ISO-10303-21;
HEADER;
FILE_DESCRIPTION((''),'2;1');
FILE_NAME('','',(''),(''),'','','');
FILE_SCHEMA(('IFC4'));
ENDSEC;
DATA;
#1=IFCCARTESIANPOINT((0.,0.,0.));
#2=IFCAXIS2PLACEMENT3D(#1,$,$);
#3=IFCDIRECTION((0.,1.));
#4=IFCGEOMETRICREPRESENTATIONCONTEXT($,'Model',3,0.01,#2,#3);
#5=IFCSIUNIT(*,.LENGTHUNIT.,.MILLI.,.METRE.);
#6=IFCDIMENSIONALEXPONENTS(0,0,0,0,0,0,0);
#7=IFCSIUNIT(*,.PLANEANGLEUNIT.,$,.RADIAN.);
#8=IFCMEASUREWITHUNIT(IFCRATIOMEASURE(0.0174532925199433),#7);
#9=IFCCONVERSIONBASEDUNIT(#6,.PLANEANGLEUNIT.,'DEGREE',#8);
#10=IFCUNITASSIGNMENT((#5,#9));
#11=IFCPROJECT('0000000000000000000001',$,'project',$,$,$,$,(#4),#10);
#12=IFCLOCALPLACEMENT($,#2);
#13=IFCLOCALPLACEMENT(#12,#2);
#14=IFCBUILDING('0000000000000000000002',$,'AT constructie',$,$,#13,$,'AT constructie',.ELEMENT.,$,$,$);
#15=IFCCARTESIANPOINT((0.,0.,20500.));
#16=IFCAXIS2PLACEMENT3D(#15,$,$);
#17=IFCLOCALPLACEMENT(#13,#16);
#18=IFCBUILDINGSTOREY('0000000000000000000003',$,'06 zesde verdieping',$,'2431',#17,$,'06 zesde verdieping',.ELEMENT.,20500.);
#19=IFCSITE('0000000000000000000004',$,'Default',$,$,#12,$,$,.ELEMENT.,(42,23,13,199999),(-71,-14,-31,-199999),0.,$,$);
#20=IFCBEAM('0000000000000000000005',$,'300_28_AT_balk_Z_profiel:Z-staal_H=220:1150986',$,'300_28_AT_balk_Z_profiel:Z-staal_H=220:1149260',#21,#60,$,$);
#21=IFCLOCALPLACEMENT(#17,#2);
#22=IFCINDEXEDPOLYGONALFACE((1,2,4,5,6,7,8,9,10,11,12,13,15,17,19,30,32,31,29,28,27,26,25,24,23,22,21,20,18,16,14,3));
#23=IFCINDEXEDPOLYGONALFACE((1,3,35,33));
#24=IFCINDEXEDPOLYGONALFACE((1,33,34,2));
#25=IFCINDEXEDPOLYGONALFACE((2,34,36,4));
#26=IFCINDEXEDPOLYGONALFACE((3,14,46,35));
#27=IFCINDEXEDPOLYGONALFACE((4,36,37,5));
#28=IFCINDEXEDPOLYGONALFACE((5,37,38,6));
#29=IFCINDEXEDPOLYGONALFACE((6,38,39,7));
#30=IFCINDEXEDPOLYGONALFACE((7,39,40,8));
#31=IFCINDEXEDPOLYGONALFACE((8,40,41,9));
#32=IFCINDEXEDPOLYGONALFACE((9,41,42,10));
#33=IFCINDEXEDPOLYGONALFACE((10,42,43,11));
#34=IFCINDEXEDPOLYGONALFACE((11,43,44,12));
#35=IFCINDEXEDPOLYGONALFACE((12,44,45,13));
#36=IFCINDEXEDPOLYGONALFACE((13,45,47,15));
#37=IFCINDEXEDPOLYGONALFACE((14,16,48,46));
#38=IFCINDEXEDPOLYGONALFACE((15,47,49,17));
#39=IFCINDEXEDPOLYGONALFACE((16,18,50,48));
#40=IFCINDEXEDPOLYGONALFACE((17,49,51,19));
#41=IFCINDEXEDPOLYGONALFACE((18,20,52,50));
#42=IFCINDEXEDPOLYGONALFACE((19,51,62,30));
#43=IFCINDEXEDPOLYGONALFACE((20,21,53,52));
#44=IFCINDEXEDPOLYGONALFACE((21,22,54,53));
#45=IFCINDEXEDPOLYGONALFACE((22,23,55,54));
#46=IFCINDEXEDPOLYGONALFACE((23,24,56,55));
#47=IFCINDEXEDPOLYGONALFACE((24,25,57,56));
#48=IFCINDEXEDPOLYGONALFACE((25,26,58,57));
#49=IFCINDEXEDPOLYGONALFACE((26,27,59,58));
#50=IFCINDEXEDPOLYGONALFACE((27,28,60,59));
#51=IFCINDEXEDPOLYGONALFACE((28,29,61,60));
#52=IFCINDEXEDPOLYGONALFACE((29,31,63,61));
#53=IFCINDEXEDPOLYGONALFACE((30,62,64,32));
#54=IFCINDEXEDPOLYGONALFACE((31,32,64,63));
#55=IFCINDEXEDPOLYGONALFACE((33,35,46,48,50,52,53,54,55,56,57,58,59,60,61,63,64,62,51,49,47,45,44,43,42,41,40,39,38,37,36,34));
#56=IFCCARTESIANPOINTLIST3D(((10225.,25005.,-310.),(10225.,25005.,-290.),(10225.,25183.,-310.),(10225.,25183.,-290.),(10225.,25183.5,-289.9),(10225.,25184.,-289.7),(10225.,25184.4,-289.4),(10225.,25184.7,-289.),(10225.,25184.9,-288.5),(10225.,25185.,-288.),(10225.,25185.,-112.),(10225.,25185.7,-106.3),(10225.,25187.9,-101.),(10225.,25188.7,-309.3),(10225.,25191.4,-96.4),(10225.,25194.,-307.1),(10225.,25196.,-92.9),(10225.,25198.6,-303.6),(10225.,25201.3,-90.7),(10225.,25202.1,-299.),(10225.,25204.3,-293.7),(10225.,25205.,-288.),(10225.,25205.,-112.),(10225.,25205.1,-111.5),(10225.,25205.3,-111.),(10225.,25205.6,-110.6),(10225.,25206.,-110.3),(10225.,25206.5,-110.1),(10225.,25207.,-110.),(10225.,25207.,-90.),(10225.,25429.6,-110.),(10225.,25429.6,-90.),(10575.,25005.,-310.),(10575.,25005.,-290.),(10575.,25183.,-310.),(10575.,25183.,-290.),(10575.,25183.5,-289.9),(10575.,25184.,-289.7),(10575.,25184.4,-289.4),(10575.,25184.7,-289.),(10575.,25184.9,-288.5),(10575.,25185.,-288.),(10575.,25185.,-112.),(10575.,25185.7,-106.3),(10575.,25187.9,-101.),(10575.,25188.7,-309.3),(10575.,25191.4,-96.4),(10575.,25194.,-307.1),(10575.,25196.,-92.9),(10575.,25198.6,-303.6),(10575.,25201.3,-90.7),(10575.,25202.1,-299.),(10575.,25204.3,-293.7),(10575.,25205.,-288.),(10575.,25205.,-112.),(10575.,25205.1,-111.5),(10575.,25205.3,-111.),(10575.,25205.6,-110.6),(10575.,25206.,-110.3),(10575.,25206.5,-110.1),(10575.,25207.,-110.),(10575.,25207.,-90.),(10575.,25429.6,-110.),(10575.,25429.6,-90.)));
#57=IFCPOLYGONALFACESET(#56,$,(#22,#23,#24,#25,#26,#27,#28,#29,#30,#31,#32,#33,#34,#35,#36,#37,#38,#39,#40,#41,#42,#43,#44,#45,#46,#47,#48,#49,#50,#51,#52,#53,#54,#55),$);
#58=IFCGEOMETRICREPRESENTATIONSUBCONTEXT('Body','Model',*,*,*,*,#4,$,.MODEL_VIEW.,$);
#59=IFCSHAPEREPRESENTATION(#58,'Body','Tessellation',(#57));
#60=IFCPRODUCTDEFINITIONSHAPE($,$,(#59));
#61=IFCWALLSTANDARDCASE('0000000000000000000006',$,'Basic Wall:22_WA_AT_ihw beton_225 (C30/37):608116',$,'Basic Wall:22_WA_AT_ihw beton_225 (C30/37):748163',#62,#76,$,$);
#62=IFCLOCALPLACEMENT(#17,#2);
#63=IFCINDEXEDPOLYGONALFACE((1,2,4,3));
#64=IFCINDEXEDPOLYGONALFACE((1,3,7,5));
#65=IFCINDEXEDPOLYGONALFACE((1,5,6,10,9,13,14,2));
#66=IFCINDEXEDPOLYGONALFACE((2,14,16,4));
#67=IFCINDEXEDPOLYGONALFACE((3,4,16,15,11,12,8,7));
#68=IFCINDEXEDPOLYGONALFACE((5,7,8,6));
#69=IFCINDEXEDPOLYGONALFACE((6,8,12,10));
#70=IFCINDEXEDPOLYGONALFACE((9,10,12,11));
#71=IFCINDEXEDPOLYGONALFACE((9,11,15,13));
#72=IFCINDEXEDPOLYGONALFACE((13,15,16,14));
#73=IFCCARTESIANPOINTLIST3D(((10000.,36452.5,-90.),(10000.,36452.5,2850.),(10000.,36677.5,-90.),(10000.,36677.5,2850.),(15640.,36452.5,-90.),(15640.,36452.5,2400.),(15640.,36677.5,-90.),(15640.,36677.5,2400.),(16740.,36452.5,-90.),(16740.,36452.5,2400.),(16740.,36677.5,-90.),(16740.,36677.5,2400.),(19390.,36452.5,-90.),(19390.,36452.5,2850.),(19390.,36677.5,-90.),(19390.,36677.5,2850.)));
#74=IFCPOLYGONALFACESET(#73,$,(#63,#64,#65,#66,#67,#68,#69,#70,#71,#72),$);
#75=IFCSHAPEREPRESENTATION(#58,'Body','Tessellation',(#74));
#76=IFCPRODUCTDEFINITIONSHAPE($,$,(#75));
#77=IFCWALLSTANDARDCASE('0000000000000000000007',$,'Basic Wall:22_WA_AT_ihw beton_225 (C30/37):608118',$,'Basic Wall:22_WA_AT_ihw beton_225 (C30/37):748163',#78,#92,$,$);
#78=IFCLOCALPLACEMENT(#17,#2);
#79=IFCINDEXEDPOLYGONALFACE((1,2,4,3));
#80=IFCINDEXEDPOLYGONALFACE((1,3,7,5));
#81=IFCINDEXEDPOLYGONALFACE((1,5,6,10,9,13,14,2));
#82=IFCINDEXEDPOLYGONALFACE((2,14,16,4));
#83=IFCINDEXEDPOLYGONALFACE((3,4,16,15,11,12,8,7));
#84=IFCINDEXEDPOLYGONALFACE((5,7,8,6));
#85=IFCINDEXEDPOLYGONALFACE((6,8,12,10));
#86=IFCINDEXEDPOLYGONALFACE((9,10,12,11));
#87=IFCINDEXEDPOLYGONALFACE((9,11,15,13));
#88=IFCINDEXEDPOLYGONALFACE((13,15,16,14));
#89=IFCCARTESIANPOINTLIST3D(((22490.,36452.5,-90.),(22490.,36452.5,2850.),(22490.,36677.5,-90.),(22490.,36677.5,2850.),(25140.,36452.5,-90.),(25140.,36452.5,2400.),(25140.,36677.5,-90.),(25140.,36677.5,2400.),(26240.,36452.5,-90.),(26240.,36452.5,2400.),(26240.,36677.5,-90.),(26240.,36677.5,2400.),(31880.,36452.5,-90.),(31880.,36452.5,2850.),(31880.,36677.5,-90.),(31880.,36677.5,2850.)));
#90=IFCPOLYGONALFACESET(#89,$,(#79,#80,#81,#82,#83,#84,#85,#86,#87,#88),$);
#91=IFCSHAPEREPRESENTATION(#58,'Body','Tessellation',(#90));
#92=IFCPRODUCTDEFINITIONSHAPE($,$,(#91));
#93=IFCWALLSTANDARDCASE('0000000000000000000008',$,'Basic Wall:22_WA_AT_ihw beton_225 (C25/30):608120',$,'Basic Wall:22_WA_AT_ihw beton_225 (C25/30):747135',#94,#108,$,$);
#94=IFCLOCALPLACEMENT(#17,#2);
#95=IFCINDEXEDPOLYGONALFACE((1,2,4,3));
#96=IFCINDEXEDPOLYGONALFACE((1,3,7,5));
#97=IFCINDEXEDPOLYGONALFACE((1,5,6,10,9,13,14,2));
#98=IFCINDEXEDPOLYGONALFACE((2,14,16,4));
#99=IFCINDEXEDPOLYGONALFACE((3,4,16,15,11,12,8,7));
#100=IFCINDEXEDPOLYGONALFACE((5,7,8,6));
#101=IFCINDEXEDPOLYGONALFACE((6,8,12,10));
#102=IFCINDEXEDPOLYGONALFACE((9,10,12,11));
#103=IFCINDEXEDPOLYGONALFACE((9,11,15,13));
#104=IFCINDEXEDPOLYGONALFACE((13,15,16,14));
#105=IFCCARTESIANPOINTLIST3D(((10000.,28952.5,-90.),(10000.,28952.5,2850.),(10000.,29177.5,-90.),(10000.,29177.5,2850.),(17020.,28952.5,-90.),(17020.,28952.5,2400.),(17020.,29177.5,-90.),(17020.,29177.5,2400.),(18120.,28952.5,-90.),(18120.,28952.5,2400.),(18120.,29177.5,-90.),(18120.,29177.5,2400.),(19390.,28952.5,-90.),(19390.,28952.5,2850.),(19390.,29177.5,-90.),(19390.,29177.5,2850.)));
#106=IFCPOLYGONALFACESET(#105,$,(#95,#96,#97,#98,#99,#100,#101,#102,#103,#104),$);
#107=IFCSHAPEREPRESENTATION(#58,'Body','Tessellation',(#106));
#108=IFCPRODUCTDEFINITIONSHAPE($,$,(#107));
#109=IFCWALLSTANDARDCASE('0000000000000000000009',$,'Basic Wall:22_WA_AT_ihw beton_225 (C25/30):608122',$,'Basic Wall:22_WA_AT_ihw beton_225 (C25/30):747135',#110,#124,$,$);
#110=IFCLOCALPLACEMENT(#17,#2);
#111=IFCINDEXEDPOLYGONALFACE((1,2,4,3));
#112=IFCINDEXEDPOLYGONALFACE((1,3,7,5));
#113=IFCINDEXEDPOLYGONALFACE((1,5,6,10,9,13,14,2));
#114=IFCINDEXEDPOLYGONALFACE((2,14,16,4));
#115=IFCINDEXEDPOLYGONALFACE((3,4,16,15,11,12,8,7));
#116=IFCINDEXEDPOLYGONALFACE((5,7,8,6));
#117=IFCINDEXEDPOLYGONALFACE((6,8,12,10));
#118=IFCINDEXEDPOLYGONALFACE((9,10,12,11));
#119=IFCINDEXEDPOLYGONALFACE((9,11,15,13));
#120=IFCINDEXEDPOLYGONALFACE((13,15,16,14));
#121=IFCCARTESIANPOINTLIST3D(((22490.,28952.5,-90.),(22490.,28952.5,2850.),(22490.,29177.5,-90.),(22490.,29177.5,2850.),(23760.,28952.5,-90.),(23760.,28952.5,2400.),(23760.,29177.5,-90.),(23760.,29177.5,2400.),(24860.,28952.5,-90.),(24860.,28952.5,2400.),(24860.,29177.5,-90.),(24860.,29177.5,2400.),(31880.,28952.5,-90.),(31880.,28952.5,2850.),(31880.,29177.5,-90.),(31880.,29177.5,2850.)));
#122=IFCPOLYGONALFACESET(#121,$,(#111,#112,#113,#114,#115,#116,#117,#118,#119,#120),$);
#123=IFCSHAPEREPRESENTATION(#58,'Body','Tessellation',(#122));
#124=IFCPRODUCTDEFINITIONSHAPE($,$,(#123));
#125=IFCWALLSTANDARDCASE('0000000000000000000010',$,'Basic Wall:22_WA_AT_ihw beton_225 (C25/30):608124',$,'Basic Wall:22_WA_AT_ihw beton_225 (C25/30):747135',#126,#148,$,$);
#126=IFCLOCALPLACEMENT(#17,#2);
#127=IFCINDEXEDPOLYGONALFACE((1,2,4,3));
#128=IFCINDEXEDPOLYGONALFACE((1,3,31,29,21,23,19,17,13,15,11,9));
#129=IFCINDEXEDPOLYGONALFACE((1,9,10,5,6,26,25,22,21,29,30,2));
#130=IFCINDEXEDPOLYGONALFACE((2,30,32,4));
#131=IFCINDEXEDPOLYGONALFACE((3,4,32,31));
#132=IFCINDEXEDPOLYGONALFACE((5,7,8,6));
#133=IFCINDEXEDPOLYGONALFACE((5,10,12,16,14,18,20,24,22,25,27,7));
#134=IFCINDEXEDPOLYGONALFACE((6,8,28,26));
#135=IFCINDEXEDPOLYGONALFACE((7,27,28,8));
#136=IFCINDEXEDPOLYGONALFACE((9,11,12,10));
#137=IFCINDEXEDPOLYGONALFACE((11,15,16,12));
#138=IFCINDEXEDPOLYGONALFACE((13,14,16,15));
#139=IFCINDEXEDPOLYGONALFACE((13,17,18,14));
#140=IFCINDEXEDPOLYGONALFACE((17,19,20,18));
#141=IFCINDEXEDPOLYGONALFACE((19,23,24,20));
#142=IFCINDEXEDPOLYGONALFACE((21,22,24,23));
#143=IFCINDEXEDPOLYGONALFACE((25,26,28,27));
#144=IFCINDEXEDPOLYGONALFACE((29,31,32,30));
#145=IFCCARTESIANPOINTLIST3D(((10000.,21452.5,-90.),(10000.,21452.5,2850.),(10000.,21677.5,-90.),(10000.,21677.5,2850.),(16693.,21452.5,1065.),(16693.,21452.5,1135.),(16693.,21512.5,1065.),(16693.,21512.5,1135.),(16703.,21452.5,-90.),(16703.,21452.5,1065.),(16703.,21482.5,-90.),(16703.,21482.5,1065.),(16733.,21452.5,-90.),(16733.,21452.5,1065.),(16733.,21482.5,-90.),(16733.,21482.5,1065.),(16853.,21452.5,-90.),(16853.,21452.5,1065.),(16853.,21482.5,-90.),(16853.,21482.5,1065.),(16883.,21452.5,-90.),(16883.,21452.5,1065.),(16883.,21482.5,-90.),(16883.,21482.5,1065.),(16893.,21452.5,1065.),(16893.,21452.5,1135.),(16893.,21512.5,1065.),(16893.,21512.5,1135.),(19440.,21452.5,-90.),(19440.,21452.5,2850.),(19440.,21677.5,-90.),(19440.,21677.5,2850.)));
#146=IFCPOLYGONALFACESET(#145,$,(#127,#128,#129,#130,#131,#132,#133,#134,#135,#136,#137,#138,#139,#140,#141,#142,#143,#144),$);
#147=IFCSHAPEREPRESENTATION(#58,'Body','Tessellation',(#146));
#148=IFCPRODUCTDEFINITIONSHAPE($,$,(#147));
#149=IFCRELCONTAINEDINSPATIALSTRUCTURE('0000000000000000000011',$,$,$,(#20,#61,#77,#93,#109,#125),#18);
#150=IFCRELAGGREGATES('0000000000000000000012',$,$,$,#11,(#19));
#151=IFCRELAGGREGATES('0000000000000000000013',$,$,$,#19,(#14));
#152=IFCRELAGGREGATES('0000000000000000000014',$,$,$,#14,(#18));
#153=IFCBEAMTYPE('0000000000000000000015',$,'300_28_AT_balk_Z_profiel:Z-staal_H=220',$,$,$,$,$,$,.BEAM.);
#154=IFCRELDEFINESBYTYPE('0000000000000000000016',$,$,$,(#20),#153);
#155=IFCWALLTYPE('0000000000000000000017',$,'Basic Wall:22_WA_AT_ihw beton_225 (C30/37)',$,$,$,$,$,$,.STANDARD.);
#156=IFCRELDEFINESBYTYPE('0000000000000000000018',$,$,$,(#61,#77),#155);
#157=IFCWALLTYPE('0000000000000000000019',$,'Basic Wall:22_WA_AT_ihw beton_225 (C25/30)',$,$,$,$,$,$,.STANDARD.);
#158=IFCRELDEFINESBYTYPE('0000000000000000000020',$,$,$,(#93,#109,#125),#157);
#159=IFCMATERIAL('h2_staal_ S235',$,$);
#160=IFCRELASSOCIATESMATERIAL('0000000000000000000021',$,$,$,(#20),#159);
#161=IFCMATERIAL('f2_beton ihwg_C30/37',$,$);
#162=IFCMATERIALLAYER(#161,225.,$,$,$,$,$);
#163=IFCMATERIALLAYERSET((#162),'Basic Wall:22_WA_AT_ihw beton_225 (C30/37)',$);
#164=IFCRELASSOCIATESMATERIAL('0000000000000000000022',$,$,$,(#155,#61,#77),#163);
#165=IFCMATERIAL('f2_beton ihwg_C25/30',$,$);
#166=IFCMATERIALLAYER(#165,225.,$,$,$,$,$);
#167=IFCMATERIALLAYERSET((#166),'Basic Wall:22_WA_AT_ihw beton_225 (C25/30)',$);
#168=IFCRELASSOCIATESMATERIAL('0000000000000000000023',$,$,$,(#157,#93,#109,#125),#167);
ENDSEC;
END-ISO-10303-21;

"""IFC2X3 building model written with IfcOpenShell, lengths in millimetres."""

from ifc_helpers import new_model, entity, si_unit, converted_unit, direction, frame, frame_2d, origin, place, context, subcontext, project, spatial, polyline, circle_curve, parameter, trimmed, segment, composite_curve, rectangle, outline, extrude, material, layer, layer_set, layer_usage, type_object, element, save


model = new_model("IFC2X3")

# Units and contexts
model_context = context("Model", 3, precision=0.01, world=origin(), true_north=direction((0.0, 1.0)))
body_context = subcontext(model_context, "Body", "Model", "MODEL_VIEW")
ifc_project = project(units=[si_unit("LENGTHUNIT", "METRE", prefix="MILLI"), converted_unit("PLANEANGLEUNIT", "DEGREE", entity("IfcRatioMeasure", 0.0174532925199433), si_unit("PLANEANGLEUNIT", "RADIAN"), dimensions=[0, 0, 0, 0, 0, 0, 0])], contexts=[model_context])

# Site, building, storey
site_placement = place(None, origin())
site = spatial("IfcSite", under=ifc_project, at=site_placement, Name="Default", CompositionType="ELEMENT", RefLatitude=(42, 23, 13, 199999), RefLongitude=(-71, -14, -31, -199999), RefElevation=0.0)
building_placement = place(site_placement, origin())
building = spatial("IfcBuilding", under=site, at=building_placement, Name="AT constructie", LongName="AT constructie", CompositionType="ELEMENT")
storey_placement = place(building_placement, frame((0.0, 0.0, 20500.0)))
storey = spatial("IfcBuildingStorey", under=building, at=storey_placement, Name="06 zesde verdieping", ObjectType="2431", LongName="06 zesde verdieping", CompositionType="ELEMENT", Elevation=20500.0)

# Beam
ifc_material_1 = material(Name="h2_staal_ S235")
beam_type_1 = type_object("IfcBeamType", Name="300_28_AT_balk_Z_profiel:Z-staal_H=220", PredefinedType="BEAM")
beam_1_placement = place(storey_placement, frame((9440.0, 25205.0, -90.0)))
element("IfcBeam", 1, at=beam_1_placement, inside=storey, type_object=beam_type_1, material=ifc_material_1, Name="300_28_AT_balk_Z_profiel:Z-staal_H=220:1150986", ObjectType="300_28_AT_balk_Z_profiel:Z-staal_H=220:1149260", context=body_context, shape_type="SweptSolid", body=[
    extrude(outline(composite_curve([segment(polyline([(90.0, -197.4), (110.0, -197.4)]), True, "CONTINUOUS"), segment(polyline([(110.0, -197.4), (110.0, -19.4)]), True, "CONTINUOUS"), segment(trimmed(circle_curve(frame_2d((88.0, -19.4), x_axis=(1.0, 0.0)), 22.0), [parameter(0.0)], [parameter(90.0)], True, "PARAMETER"), True, "CONTINUOUS"), segment(polyline([(88.0, 2.6), (-88.0, 2.6)]), True, "CONTINUOUS"), segment(trimmed(circle_curve(frame_2d((-88.0, 4.6), x_axis=(0.0, -1.0)), 2.0), [parameter(270.0)], [parameter(0.0)], True, "PARAMETER"), False, "CONTINUOUS"), segment(polyline([(-90.0, 4.6), (-90.0, 227.2)]), True, "CONTINUOUS"), segment(polyline([(-90.0, 227.2), (-110.0, 227.2)]), True, "CONTINUOUS"), segment(polyline([(-110.0, 227.2), (-110.0, 4.6)]), True, "CONTINUOUS"), segment(trimmed(circle_curve(frame_2d((-88.0, 4.6), x_axis=(-1.0, 0.0)), 22.0), [parameter(0.0)], [parameter(90.0)], True, "PARAMETER"), True, "CONTINUOUS"), segment(polyline([(-88.0, -17.4), (88.0, -17.4)]), True, "CONTINUOUS"), segment(trimmed(circle_curve(frame_2d((88.0, -19.4), x_axis=(0.0, 1.0)), 2.0), [parameter(270.0)], [parameter(0.0)], True, "PARAMETER"), False, "CONTINUOUS"), segment(polyline([(90.0, -19.4), (90.0, -197.4)]), True, "CONTINUOUS")], self_intersect=False)), frame((785.0, -2.6, -110.0), z_axis=(1.0, 0.0, 0.0), x_axis=(0.0, 0.0, -1.0)), (0.0, 0.0, 1.0), 350.0),
])

# Walls, openings
ifc_material_2 = material(Name="f2_beton ihwg_C30/37")
ifc_layer_1 = layer(ifc_material_2, 225.0)
ifc_layer_set_1 = layer_set([ifc_layer_1], Name="Basic Wall:22_WA_AT_ihw beton_225 (C30/37)")
ifc_layer_usage_1 = layer_usage(ifc_layer_set_1, "AXIS2", "NEGATIVE", 112.5)
wall_type_1 = type_object("IfcWallType", Name="Basic Wall:22_WA_AT_ihw beton_225 (C30/37)", PredefinedType="STANDARD", material=ifc_layer_set_1)
wall_1_placement = place(storey_placement, frame((10000.0, 36565.0, -90.0)))
wall_1 = element("IfcWallStandardCase", 2, at=wall_1_placement, inside=storey, type_object=wall_type_1, material=ifc_layer_usage_1, Name="Basic Wall:22_WA_AT_ihw beton_225 (C30/37):608116", ObjectType="Basic Wall:22_WA_AT_ihw beton_225 (C30/37):748163", context=body_context, shape_type="SweptSolid", body=[
    extrude(rectangle(XDim=9390.0, YDim=225.0, at=frame_2d((4695.0, 0.0), x_axis=(-1.0, 0.0))), origin(), (0.0, 0.0, 1.0), 2940.0),
])
opening_1_placement = place(wall_1_placement, origin())
element("IfcOpeningElement", 3, at=opening_1_placement, cuts=wall_1, ObjectType="Opening", context=body_context, shape_type="SweptSolid", body=[
    extrude(rectangle(XDim=2490.0, YDim=1100.0, at=frame_2d((0.0, 0.0), x_axis=(1.0, 0.0))), frame((6190.0, -1411.5, 1245.0), z_axis=(0.0, 1.0, 0.0), x_axis=(0.0, 0.0, -1.0)), (0.0, 0.0, 1.0), 3048.0),
])
ifc_layer_usage_2 = layer_usage(ifc_layer_set_1, "AXIS2", "NEGATIVE", 112.5)
wall_2_placement = place(storey_placement, frame((22490.0, 36565.0, -90.0)))
wall_2 = element("IfcWallStandardCase", 4, at=wall_2_placement, inside=storey, type_object=wall_type_1, material=ifc_layer_usage_2, Name="Basic Wall:22_WA_AT_ihw beton_225 (C30/37):608118", ObjectType="Basic Wall:22_WA_AT_ihw beton_225 (C30/37):748163", context=body_context, shape_type="SweptSolid", body=[
    extrude(rectangle(XDim=9390.0, YDim=225.0, at=frame_2d((4695.0, 0.0), x_axis=(-1.0, 0.0))), origin(), (0.0, 0.0, 1.0), 2940.0),
])
opening_2_placement = place(wall_2_placement, origin())
element("IfcOpeningElement", 5, at=opening_2_placement, cuts=wall_2, ObjectType="Opening", context=body_context, shape_type="SweptSolid", body=[
    extrude(rectangle(XDim=2490.0, YDim=1100.0, at=frame_2d((0.0, 0.0), x_axis=(1.0, 0.0))), frame((3200.0, -1411.5, 1245.0), z_axis=(0.0, 1.0, 0.0), x_axis=(0.0, 0.0, -1.0)), (0.0, 0.0, 1.0), 3048.0),
])
ifc_material_3 = material(Name="f2_beton ihwg_C25/30")
ifc_layer_2 = layer(ifc_material_3, 225.0)
ifc_layer_set_2 = layer_set([ifc_layer_2], Name="Basic Wall:22_WA_AT_ihw beton_225 (C25/30)")
ifc_layer_usage_3 = layer_usage(ifc_layer_set_2, "AXIS2", "NEGATIVE", 112.5)
wall_type_2 = type_object("IfcWallType", Name="Basic Wall:22_WA_AT_ihw beton_225 (C25/30)", PredefinedType="STANDARD", material=ifc_layer_set_2)
wall_3_placement = place(storey_placement, frame((10000.0, 29065.0, -90.0)))
wall_3 = element("IfcWallStandardCase", 6, at=wall_3_placement, inside=storey, type_object=wall_type_2, material=ifc_layer_usage_3, Name="Basic Wall:22_WA_AT_ihw beton_225 (C25/30):608120", ObjectType="Basic Wall:22_WA_AT_ihw beton_225 (C25/30):747135", context=body_context, shape_type="SweptSolid", body=[
    extrude(rectangle(XDim=9390.0, YDim=225.0, at=frame_2d((4695.0, 0.0), x_axis=(-1.0, 0.0))), origin(), (0.0, 0.0, 1.0), 2940.0),
])
opening_3_placement = place(wall_3_placement, origin())
element("IfcOpeningElement", 7, at=opening_3_placement, cuts=wall_3, ObjectType="Opening", context=body_context, shape_type="SweptSolid", body=[
    extrude(rectangle(XDim=2490.0, YDim=1100.0, at=frame_2d((0.0, 0.0), x_axis=(1.0, 0.0))), frame((7570.0, -1411.5, 1245.0), z_axis=(0.0, 1.0, 0.0), x_axis=(0.0, 0.0, -1.0)), (0.0, 0.0, 1.0), 3048.0),
])
ifc_layer_usage_4 = layer_usage(ifc_layer_set_2, "AXIS2", "NEGATIVE", 112.5)
wall_4_placement = place(storey_placement, frame((22490.0, 29065.0, -90.0)))
wall_4 = element("IfcWallStandardCase", 8, at=wall_4_placement, inside=storey, type_object=wall_type_2, material=ifc_layer_usage_4, Name="Basic Wall:22_WA_AT_ihw beton_225 (C25/30):608122", ObjectType="Basic Wall:22_WA_AT_ihw beton_225 (C25/30):747135", context=body_context, shape_type="SweptSolid", body=[
    extrude(rectangle(XDim=9390.0, YDim=225.0, at=frame_2d((4695.0, 0.0), x_axis=(-1.0, 0.0))), origin(), (0.0, 0.0, 1.0), 2940.0),
])
opening_4_placement = place(wall_4_placement, origin())
element("IfcOpeningElement", 9, at=opening_4_placement, cuts=wall_4, ObjectType="Opening", context=body_context, shape_type="SweptSolid", body=[
    extrude(rectangle(XDim=2490.0, YDim=1100.0, at=frame_2d((0.0, 0.0), x_axis=(1.0, 0.0))), frame((1820.0, -1411.5, 1245.0), z_axis=(0.0, 1.0, 0.0), x_axis=(0.0, 0.0, -1.0)), (0.0, 0.0, 1.0), 3048.0),
])

# Wall, openings
ifc_layer_usage_5 = layer_usage(ifc_layer_set_2, "AXIS2", "NEGATIVE", 112.5)
wall_5_placement = place(storey_placement, frame((10000.0, 21565.0, -90.0)))
wall_5 = element("IfcWallStandardCase", 10, at=wall_5_placement, inside=storey, type_object=wall_type_2, material=ifc_layer_usage_5, Name="Basic Wall:22_WA_AT_ihw beton_225 (C25/30):608124", ObjectType="Basic Wall:22_WA_AT_ihw beton_225 (C25/30):747135", context=body_context, shape_type="SweptSolid", body=[
    extrude(rectangle(XDim=9440.0, YDim=225.0, at=frame_2d((4720.0, 0.0), x_axis=(-1.0, 0.0))), origin(), (0.0, 0.0, 1.0), 2940.0),
])
opening_5_placement = place(wall_5_placement, origin())
element("IfcOpeningElement", 11, at=opening_5_placement, cuts=wall_5, ObjectType="Recess", context=body_context, shape_type="SweptSolid", body=[
    extrude(rectangle(XDim=1155.0, YDim=30.0, at=frame_2d((0.0, 0.0), x_axis=(1.0, 0.0))), frame((6718.0, -112.5, 577.5), z_axis=(0.0, 1.0, 0.0), x_axis=(0.0, 0.0, -1.0)), (0.0, 0.0, 1.0), 30.0),
])
opening_6_placement = place(wall_5_placement, origin())
element("IfcOpeningElement", 12, at=opening_6_placement, cuts=wall_5, ObjectType="Recess", context=body_context, shape_type="SweptSolid", body=[
    extrude(rectangle(XDim=1155.0, YDim=30.0, at=frame_2d((0.0, 0.0), x_axis=(1.0, 0.0))), frame((6868.0, -112.5, 577.5), z_axis=(0.0, 1.0, 0.0), x_axis=(0.0, 0.0, -1.0)), (0.0, 0.0, 1.0), 30.0),
])
opening_7_placement = place(wall_5_placement, origin())
element("IfcOpeningElement", 13, at=opening_7_placement, cuts=wall_5, ObjectType="Recess", context=body_context, shape_type="SweptSolid", body=[
    extrude(rectangle(XDim=70.0, YDim=200.0, at=frame_2d((0.0, 0.0), x_axis=(1.0, 0.0))), frame((6793.0, -112.5, 1190.0), z_axis=(0.0, 1.0, 0.0), x_axis=(0.0, 0.0, -1.0)), (0.0, 0.0, 1.0), 60.0),
])

save(model, "model.ifc")
